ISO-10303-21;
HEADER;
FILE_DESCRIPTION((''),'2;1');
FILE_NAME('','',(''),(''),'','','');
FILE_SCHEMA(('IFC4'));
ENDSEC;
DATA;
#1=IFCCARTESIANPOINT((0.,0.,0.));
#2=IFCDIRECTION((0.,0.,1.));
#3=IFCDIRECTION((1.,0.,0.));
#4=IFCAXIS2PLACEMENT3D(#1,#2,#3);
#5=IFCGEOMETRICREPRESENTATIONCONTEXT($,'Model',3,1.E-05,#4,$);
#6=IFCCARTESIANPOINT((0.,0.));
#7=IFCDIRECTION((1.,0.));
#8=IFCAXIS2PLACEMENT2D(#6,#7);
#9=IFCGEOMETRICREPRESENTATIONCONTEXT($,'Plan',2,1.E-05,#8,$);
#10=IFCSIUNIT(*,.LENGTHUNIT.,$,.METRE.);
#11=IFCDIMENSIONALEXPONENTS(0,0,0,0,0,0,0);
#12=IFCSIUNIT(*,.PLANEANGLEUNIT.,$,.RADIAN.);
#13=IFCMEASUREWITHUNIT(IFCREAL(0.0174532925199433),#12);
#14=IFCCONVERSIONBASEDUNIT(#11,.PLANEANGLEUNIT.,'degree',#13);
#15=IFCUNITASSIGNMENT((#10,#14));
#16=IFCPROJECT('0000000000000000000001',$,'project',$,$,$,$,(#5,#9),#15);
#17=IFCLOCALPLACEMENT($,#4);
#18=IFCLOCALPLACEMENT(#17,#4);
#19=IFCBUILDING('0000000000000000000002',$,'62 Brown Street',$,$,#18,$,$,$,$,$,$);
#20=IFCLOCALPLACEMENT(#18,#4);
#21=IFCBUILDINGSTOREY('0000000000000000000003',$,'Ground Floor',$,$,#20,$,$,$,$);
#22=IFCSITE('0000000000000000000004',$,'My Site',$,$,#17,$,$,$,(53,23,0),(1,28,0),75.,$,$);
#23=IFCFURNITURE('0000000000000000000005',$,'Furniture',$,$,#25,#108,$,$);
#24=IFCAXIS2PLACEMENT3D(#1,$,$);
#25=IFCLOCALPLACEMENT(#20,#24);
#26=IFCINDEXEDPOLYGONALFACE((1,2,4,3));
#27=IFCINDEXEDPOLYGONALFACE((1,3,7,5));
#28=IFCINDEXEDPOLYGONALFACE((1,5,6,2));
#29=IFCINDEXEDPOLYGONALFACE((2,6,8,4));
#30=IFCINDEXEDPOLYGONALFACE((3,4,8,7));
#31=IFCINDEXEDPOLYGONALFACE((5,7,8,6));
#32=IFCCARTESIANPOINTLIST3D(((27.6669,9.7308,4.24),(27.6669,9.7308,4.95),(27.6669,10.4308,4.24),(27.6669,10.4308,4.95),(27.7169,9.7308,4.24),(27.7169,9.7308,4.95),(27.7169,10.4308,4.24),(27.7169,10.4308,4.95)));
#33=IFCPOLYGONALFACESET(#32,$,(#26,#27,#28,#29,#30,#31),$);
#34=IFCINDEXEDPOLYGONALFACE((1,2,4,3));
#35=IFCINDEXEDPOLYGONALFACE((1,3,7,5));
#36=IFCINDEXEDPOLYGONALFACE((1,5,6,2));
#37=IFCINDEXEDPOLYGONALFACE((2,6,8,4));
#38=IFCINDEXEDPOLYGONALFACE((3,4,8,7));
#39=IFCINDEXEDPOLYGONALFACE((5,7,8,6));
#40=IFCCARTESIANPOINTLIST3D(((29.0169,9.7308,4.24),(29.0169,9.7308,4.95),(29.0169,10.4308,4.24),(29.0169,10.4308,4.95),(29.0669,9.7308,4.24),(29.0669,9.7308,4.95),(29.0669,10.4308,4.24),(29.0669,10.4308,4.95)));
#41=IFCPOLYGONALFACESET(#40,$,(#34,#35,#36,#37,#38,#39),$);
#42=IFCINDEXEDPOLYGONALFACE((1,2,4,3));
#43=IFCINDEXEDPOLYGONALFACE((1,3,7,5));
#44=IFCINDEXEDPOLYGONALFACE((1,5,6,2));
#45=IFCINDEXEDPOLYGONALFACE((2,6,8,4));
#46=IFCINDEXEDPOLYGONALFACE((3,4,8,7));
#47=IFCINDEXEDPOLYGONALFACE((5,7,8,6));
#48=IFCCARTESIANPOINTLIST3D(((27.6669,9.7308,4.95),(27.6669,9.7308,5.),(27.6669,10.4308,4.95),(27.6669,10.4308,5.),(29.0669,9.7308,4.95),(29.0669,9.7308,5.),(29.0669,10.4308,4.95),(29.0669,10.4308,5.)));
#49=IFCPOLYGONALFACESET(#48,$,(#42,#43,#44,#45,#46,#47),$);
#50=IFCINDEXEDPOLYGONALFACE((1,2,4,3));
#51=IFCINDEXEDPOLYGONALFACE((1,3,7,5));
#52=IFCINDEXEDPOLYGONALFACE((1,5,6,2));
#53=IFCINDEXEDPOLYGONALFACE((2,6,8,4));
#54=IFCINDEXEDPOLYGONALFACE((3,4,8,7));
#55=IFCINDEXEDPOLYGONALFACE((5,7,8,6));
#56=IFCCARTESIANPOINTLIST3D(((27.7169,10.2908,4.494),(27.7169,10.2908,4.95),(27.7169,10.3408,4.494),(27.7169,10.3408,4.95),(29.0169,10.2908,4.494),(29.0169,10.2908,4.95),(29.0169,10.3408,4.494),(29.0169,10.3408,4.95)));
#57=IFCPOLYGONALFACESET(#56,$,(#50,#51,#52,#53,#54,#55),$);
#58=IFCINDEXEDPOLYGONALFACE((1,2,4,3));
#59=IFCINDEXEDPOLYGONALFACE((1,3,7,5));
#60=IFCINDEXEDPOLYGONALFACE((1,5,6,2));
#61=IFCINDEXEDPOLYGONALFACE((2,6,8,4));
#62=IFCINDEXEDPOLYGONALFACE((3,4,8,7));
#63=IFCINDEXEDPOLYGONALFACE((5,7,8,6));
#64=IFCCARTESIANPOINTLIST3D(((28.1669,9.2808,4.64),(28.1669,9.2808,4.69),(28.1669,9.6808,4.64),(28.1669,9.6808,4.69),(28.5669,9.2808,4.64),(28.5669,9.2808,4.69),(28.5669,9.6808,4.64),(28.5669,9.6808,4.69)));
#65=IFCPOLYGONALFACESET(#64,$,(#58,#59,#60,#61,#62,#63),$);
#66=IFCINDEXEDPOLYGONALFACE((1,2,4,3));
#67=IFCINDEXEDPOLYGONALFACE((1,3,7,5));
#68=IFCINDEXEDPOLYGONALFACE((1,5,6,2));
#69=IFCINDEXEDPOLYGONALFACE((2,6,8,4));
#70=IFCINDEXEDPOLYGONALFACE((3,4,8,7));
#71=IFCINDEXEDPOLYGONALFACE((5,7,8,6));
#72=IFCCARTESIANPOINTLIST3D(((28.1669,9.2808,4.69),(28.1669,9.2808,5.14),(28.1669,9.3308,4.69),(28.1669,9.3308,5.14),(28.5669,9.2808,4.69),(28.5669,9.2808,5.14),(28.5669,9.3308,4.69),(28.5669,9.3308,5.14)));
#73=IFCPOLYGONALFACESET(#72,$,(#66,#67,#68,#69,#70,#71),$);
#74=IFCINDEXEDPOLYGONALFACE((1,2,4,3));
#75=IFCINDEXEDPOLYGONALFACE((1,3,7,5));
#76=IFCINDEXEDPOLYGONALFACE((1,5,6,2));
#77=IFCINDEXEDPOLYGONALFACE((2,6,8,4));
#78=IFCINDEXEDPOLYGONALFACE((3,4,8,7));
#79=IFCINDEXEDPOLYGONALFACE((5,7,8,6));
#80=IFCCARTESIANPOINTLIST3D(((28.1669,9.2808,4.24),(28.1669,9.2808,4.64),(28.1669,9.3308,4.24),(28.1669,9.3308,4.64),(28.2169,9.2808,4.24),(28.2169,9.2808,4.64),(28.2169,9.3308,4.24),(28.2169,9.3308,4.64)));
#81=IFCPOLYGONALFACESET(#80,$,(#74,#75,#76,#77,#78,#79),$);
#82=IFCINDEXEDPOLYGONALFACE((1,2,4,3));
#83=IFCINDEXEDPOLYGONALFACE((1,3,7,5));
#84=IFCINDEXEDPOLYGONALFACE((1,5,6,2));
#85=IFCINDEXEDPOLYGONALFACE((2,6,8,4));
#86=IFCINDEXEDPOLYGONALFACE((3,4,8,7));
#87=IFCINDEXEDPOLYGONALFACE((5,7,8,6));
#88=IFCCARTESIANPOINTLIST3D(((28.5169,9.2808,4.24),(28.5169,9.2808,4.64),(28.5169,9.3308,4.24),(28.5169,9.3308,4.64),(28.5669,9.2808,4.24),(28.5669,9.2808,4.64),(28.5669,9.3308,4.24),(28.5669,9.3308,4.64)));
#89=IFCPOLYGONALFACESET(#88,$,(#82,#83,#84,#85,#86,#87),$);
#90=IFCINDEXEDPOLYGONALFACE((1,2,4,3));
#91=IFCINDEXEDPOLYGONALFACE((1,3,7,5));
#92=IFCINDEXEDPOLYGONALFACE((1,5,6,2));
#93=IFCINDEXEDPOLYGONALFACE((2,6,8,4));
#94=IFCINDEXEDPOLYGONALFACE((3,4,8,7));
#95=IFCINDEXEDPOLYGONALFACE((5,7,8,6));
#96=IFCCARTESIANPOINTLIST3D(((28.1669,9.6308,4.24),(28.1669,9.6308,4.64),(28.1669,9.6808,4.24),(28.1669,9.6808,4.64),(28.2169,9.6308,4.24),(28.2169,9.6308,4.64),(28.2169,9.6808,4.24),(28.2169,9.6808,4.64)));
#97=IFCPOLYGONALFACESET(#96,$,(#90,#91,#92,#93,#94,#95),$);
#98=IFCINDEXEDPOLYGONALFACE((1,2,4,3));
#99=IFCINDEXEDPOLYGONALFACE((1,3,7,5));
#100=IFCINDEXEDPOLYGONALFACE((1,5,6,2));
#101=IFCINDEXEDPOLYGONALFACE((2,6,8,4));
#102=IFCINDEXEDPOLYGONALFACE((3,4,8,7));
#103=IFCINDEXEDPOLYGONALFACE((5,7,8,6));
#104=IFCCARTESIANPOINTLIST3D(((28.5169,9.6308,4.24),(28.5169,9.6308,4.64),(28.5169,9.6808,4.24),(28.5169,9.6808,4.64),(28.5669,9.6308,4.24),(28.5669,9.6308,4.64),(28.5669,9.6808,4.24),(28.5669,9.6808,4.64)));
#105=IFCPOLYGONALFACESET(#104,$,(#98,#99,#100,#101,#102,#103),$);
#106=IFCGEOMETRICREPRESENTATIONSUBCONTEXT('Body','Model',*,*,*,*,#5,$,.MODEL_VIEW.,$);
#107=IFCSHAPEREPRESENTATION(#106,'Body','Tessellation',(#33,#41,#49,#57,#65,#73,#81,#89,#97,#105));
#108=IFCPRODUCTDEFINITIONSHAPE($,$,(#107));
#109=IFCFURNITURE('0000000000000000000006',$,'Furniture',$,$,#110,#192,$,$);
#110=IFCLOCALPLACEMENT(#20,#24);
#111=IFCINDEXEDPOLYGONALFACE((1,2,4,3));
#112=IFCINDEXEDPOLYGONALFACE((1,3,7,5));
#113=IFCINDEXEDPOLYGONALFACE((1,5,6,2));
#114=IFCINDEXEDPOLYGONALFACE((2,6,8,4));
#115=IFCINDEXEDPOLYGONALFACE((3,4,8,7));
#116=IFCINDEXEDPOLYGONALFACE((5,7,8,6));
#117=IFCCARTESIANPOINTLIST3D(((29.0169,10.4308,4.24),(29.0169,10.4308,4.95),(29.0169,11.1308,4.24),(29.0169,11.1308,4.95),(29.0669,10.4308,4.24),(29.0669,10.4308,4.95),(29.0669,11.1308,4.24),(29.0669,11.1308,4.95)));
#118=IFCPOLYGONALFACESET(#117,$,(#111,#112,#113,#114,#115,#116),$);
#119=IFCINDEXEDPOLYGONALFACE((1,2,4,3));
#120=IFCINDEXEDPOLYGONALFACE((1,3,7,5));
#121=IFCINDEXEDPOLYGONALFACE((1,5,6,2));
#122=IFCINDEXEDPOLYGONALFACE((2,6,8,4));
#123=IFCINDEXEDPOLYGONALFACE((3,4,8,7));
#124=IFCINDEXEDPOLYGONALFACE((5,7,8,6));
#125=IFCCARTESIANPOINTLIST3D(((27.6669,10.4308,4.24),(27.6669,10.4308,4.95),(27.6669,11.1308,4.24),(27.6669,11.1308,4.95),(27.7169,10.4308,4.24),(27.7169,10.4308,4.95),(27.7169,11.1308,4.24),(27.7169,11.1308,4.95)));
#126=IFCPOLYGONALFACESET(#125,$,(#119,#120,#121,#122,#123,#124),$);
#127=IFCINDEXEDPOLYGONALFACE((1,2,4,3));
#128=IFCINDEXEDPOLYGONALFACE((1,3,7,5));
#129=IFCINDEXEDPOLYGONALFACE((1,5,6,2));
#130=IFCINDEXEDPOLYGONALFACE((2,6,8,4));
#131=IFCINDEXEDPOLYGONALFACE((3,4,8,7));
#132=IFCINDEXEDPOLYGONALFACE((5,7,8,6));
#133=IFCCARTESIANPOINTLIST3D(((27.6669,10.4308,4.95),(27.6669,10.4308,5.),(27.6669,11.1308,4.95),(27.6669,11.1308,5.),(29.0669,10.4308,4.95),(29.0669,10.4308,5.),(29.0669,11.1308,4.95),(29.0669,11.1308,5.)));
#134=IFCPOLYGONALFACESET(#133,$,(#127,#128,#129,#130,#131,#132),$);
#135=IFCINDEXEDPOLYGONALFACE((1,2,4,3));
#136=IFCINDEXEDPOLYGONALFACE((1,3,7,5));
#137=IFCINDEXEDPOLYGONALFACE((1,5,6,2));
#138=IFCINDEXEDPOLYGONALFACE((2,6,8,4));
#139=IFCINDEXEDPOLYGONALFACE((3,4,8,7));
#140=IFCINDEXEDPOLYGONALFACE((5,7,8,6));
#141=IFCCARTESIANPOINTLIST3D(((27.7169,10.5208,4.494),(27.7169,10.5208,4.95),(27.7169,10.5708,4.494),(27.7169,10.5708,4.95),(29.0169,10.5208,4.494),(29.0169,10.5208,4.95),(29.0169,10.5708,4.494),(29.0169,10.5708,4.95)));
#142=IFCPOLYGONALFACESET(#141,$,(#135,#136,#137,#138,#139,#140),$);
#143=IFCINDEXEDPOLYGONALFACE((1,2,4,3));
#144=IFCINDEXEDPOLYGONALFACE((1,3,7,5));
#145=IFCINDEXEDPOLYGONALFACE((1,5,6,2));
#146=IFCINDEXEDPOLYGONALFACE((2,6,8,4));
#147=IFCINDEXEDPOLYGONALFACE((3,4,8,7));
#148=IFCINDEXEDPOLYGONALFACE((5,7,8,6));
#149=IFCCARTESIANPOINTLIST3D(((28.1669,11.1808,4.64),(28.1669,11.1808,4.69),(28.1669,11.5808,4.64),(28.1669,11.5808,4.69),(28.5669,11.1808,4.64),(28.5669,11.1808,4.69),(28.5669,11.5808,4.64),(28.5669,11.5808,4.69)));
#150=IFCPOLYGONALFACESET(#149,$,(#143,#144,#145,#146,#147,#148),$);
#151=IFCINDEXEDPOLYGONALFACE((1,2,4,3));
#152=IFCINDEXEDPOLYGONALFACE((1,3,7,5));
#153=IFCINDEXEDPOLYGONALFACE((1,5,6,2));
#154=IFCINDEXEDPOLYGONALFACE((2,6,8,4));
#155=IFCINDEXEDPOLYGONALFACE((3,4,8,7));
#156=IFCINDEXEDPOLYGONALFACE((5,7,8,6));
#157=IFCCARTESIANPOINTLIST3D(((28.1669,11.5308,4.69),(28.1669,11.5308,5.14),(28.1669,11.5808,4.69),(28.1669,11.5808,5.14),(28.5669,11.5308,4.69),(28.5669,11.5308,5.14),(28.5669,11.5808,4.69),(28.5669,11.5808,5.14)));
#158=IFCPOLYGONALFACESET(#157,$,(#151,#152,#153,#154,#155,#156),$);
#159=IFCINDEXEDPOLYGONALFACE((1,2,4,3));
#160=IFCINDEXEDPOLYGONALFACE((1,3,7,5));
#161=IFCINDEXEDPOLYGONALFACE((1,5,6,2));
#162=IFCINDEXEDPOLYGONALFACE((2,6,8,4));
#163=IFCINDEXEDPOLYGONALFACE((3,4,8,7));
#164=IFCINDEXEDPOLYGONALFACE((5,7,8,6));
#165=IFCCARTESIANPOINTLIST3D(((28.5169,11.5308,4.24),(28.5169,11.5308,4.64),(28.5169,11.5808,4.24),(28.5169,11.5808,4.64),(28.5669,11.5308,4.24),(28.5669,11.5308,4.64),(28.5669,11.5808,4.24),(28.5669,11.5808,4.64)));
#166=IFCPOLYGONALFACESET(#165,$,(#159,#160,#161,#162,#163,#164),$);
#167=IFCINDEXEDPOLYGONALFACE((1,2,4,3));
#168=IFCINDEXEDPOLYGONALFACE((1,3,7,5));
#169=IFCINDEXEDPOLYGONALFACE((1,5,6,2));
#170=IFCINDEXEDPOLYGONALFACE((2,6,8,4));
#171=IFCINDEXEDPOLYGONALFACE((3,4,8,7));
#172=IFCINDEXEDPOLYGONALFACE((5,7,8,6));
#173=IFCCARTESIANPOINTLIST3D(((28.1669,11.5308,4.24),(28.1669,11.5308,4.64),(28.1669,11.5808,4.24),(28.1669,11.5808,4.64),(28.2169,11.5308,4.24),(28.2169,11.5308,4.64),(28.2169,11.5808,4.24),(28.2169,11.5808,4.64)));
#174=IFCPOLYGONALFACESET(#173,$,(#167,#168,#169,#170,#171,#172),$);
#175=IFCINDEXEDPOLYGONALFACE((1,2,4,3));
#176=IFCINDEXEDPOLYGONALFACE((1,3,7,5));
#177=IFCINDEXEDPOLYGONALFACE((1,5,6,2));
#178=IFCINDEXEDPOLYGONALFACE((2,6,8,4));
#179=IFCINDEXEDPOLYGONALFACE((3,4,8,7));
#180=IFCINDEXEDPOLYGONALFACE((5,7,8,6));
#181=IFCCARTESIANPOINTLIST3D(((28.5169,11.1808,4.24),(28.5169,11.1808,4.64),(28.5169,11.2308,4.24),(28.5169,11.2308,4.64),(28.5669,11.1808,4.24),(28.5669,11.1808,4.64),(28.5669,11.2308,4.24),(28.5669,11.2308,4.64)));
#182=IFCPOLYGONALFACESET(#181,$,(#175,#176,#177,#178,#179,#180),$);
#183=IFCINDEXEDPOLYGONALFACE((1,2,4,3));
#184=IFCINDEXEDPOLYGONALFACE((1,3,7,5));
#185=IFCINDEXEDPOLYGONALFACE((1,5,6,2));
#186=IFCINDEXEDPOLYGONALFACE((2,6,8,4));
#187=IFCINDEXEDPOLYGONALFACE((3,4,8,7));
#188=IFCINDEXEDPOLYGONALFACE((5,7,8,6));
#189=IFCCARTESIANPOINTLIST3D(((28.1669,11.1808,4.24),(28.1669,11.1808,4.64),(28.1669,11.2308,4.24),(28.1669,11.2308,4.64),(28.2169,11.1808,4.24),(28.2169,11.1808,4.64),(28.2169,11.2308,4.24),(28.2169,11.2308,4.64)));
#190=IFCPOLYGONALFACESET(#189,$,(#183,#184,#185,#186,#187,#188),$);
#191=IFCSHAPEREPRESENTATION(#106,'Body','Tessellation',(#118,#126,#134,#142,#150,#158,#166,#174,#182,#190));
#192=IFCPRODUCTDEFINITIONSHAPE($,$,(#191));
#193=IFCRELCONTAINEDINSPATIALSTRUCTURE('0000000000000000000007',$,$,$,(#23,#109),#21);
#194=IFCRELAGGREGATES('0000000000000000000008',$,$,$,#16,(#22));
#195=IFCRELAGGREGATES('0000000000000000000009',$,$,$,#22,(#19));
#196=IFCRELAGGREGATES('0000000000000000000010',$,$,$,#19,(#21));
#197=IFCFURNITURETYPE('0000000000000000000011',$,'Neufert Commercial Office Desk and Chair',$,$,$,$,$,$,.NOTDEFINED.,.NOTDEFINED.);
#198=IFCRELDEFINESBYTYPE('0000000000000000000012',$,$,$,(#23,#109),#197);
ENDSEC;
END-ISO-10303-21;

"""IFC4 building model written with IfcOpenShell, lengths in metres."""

from ifc_helpers import new_model, entity, si_unit, converted_unit, frame, origin_with_axes, origin_2d_with_axis, place, context, subcontext, project, spatial, line, indexed_curve, outline, extrude, shape, source, transform, mapped, type_object, type_shapes, element, save


model = new_model("IFC4")

# Units and contexts
model_context = context("Model", 3, precision=1e-05, world=origin_with_axes())
plan_context = context("Plan", 2, precision=1e-05, world=origin_2d_with_axis())
body_context_1 = subcontext(model_context, "Body", "Model", "MODEL_VIEW")
body_context_2 = subcontext(plan_context, "Body", "Plan", "PLAN_VIEW")
ifc_project = project(units=[si_unit("LENGTHUNIT", "METRE"), converted_unit("PLANEANGLEUNIT", "degree", entity("IfcReal", 0.0174532925199433), si_unit("PLANEANGLEUNIT", "RADIAN"), dimensions=[0, 0, 0, 0, 0, 0, 0])], contexts=[model_context, plan_context])

# Site, building, storey
site_placement = place(None, origin_with_axes())
site = spatial("IfcSite", under=ifc_project, at=site_placement, Name="My Site", RefLatitude=(53, 23, 0), RefLongitude=(1, 28, 0), RefElevation=75.0)
building_placement = place(site_placement, origin_with_axes())
building = spatial("IfcBuilding", under=site, at=building_placement, Name="62 Brown Street")
storey_placement = place(building_placement, origin_with_axes())
storey = spatial("IfcBuildingStorey", under=building, at=storey_placement, Name="Ground Floor")

# Furniture
furniture_type_1 = type_object("IfcFurnitureType", Name="Neufert Commercial Office Desk and Chair", AssemblyPlace="NOTDEFINED", PredefinedType="NOTDEFINED")
shared_shape_1 = source(origin_with_axes(), body_context_1, "Body", "SweptSolid", [
    extrude(outline(indexed_curve([(0.0, 0.0), (0.05, 0.0), (0.05, 0.7), (0.0, 0.7)], segments=[line(1, 2, 3, 4, 1)])), frame((0.0, 0.45, 0.0), z_axis=(0.0, 0.0, 1.0), x_axis=(1.0, 0.0, 0.0)), (0.0, 0.0, 1.0), 0.71),
    extrude(outline(indexed_curve([(0.0, 0.0), (0.05, 0.0), (0.05, 0.7), (0.0, 0.7)], segments=[line(1, 2, 3, 4, 1)])), frame((1.35, 0.45, 0.0), z_axis=(0.0, 0.0, 1.0), x_axis=(1.0, 0.0, 0.0)), (0.0, 0.0, 1.0), 0.71),
    extrude(outline(indexed_curve([(0.0, 0.0), (1.4, 0.0), (1.4, 0.7), (0.0, 0.7)], segments=[line(1, 2, 3, 4, 1)])), frame((0.0, 0.45, 0.71), z_axis=(0.0, 0.0, 1.0), x_axis=(1.0, 0.0, 0.0)), (0.0, 0.0, 1.0), 0.05),
    extrude(outline(indexed_curve([(0.05, 0.56), (1.35, 0.56), (1.35, 0.61), (0.05, 0.61)], segments=[line(1, 2, 3, 4, 1)])), frame((0.0, 0.45, 0.254), z_axis=(0.0, 0.0, 1.0), x_axis=(1.0, 0.0, 0.0)), (0.0, 0.0, 1.0), 0.456),
    extrude(outline(indexed_curve([(-0.2, 0.0), (0.2, 0.0), (0.2, 0.4), (-0.2, 0.4)], segments=[line(1, 2, 3, 4, 1)])), frame((0.7, 0.0, 0.45), z_axis=(0.0, 0.0, 1.0), x_axis=(1.0, 0.0, 0.0)), (0.0, 0.0, -1.0), 0.05),
    extrude(outline(indexed_curve([(-0.2, 0.0), (0.2, 0.0), (0.2, 0.05), (-0.2, 0.05)], segments=[line(1, 2, 3, 4, 1)])), frame((0.7, 0.0, 0.9), z_axis=(0.0, 0.0, 1.0), x_axis=(1.0, 0.0, 0.0)), (0.0, 0.0, -1.0), 0.45),
    extrude(outline(indexed_curve([(-0.2, 0.0), (-0.15, 0.0), (-0.15, 0.05), (-0.2, 0.05)], segments=[line(1, 2, 3, 4, 1)])), frame((0.7, 0.0, 0.0), z_axis=(0.0, 0.0, 1.0), x_axis=(1.0, 0.0, 0.0)), (0.0, 0.0, 1.0), 0.4),
    extrude(outline(indexed_curve([(0.2, 0.0), (0.15, 0.0), (0.15, 0.05), (0.2, 0.05)], segments=[line(1, 2, 3, 4, 1)])), frame((0.7, 0.0, 0.0), z_axis=(0.0, 0.0, 1.0), x_axis=(1.0, 0.0, 0.0)), (0.0, 0.0, 1.0), 0.4),
    extrude(outline(indexed_curve([(-0.2, 0.4), (-0.15, 0.4), (-0.15, 0.35), (-0.2, 0.35)], segments=[line(1, 2, 3, 4, 1)])), frame((0.7, 0.0, 0.0), z_axis=(0.0, 0.0, 1.0), x_axis=(1.0, 0.0, 0.0)), (0.0, 0.0, 1.0), 0.4),
    extrude(outline(indexed_curve([(0.2, 0.4), (0.15, 0.4), (0.15, 0.35), (0.2, 0.35)], segments=[line(1, 2, 3, 4, 1)])), frame((0.7, 0.0, 0.0), z_axis=(0.0, 0.0, 1.0), x_axis=(1.0, 0.0, 0.0)), (0.0, 0.0, 1.0), 0.4),
])
shared_shape_2 = source(origin_with_axes(), body_context_2, "Body", "Curve2D", [
    entity("IfcIndexedPolyCurve", entity("IfcCartesianPointList2D", [[0.0, 0.45], [1.4, 0.45], [1.4, 1.15], [0.0, 1.15]]), [entity("IfcLineIndex", [1, 2, 3, 4, 1])]),
    entity("IfcIndexedPolyCurve", entity("IfcCartesianPointList2D", [[0.5, 0.4], [0.9, 0.4]])),
    entity("IfcIndexedPolyCurve", entity("IfcCartesianPointList2D", [[0.5, 0.4], [0.5, 0.2], [0.5586, 0.0586], [0.7, 0.0], [0.8414, 0.0586], [0.9, 0.2], [0.9, 0.4]]), [entity("IfcLineIndex", [1, 2]), entity("IfcArcIndex", [2, 3, 4]), entity("IfcArcIndex", [4, 5, 6]), entity("IfcLineIndex", [6, 7])]),
    entity("IfcIndexedPolyCurve", entity("IfcCartesianPointList2D", [[0.54, 0.4], [0.54, 0.2], [0.5869, 0.0869], [0.7, 0.04], [0.8131, 0.0869], [0.86, 0.2], [0.86, 0.4]]), [entity("IfcLineIndex", [1, 2]), entity("IfcArcIndex", [2, 3, 4]), entity("IfcArcIndex", [4, 5, 6]), entity("IfcLineIndex", [6, 7])]),
])
type_shapes(furniture_type_1, [shared_shape_1, shared_shape_2])
for number, where, z_axis, x_axis, name in (
    (1, (27.6669, 9.2808, 4.24), (0.0, 0.0, 1.0), (1.0, 0.0, 0.0), "Furniture"),
    (2, (29.0669, 11.5808, 4.24), (0.0, 0.0, 1.0), (-1.0, 0.0, 0.0), "Furniture"),
):
    element("IfcFurniture", number, at=place(storey_placement, frame(where, z_axis=z_axis, x_axis=x_axis)), inside=storey, type_object=furniture_type_1, Name=name, shapes=[
        shape(body_context_1, "Body", "MappedRepresentation", [mapped(shared_shape_1, transform((0.0, 0.0, 0.0), x_axis=(1.0, 0.0, 0.0), y_axis=(0.0, 1.0, 0.0), z_axis=(0.0, 0.0, 1.0), scale=1.0))]),
        shape(body_context_2, "Body", "MappedRepresentation", [mapped(shared_shape_2, transform((0.0, 0.0, 0.0), x_axis=(1.0, 0.0, 0.0), y_axis=(0.0, 1.0, 0.0), z_axis=(0.0, 0.0, 1.0), scale=1.0))]),
    ])

save(model, "model.ifc")
